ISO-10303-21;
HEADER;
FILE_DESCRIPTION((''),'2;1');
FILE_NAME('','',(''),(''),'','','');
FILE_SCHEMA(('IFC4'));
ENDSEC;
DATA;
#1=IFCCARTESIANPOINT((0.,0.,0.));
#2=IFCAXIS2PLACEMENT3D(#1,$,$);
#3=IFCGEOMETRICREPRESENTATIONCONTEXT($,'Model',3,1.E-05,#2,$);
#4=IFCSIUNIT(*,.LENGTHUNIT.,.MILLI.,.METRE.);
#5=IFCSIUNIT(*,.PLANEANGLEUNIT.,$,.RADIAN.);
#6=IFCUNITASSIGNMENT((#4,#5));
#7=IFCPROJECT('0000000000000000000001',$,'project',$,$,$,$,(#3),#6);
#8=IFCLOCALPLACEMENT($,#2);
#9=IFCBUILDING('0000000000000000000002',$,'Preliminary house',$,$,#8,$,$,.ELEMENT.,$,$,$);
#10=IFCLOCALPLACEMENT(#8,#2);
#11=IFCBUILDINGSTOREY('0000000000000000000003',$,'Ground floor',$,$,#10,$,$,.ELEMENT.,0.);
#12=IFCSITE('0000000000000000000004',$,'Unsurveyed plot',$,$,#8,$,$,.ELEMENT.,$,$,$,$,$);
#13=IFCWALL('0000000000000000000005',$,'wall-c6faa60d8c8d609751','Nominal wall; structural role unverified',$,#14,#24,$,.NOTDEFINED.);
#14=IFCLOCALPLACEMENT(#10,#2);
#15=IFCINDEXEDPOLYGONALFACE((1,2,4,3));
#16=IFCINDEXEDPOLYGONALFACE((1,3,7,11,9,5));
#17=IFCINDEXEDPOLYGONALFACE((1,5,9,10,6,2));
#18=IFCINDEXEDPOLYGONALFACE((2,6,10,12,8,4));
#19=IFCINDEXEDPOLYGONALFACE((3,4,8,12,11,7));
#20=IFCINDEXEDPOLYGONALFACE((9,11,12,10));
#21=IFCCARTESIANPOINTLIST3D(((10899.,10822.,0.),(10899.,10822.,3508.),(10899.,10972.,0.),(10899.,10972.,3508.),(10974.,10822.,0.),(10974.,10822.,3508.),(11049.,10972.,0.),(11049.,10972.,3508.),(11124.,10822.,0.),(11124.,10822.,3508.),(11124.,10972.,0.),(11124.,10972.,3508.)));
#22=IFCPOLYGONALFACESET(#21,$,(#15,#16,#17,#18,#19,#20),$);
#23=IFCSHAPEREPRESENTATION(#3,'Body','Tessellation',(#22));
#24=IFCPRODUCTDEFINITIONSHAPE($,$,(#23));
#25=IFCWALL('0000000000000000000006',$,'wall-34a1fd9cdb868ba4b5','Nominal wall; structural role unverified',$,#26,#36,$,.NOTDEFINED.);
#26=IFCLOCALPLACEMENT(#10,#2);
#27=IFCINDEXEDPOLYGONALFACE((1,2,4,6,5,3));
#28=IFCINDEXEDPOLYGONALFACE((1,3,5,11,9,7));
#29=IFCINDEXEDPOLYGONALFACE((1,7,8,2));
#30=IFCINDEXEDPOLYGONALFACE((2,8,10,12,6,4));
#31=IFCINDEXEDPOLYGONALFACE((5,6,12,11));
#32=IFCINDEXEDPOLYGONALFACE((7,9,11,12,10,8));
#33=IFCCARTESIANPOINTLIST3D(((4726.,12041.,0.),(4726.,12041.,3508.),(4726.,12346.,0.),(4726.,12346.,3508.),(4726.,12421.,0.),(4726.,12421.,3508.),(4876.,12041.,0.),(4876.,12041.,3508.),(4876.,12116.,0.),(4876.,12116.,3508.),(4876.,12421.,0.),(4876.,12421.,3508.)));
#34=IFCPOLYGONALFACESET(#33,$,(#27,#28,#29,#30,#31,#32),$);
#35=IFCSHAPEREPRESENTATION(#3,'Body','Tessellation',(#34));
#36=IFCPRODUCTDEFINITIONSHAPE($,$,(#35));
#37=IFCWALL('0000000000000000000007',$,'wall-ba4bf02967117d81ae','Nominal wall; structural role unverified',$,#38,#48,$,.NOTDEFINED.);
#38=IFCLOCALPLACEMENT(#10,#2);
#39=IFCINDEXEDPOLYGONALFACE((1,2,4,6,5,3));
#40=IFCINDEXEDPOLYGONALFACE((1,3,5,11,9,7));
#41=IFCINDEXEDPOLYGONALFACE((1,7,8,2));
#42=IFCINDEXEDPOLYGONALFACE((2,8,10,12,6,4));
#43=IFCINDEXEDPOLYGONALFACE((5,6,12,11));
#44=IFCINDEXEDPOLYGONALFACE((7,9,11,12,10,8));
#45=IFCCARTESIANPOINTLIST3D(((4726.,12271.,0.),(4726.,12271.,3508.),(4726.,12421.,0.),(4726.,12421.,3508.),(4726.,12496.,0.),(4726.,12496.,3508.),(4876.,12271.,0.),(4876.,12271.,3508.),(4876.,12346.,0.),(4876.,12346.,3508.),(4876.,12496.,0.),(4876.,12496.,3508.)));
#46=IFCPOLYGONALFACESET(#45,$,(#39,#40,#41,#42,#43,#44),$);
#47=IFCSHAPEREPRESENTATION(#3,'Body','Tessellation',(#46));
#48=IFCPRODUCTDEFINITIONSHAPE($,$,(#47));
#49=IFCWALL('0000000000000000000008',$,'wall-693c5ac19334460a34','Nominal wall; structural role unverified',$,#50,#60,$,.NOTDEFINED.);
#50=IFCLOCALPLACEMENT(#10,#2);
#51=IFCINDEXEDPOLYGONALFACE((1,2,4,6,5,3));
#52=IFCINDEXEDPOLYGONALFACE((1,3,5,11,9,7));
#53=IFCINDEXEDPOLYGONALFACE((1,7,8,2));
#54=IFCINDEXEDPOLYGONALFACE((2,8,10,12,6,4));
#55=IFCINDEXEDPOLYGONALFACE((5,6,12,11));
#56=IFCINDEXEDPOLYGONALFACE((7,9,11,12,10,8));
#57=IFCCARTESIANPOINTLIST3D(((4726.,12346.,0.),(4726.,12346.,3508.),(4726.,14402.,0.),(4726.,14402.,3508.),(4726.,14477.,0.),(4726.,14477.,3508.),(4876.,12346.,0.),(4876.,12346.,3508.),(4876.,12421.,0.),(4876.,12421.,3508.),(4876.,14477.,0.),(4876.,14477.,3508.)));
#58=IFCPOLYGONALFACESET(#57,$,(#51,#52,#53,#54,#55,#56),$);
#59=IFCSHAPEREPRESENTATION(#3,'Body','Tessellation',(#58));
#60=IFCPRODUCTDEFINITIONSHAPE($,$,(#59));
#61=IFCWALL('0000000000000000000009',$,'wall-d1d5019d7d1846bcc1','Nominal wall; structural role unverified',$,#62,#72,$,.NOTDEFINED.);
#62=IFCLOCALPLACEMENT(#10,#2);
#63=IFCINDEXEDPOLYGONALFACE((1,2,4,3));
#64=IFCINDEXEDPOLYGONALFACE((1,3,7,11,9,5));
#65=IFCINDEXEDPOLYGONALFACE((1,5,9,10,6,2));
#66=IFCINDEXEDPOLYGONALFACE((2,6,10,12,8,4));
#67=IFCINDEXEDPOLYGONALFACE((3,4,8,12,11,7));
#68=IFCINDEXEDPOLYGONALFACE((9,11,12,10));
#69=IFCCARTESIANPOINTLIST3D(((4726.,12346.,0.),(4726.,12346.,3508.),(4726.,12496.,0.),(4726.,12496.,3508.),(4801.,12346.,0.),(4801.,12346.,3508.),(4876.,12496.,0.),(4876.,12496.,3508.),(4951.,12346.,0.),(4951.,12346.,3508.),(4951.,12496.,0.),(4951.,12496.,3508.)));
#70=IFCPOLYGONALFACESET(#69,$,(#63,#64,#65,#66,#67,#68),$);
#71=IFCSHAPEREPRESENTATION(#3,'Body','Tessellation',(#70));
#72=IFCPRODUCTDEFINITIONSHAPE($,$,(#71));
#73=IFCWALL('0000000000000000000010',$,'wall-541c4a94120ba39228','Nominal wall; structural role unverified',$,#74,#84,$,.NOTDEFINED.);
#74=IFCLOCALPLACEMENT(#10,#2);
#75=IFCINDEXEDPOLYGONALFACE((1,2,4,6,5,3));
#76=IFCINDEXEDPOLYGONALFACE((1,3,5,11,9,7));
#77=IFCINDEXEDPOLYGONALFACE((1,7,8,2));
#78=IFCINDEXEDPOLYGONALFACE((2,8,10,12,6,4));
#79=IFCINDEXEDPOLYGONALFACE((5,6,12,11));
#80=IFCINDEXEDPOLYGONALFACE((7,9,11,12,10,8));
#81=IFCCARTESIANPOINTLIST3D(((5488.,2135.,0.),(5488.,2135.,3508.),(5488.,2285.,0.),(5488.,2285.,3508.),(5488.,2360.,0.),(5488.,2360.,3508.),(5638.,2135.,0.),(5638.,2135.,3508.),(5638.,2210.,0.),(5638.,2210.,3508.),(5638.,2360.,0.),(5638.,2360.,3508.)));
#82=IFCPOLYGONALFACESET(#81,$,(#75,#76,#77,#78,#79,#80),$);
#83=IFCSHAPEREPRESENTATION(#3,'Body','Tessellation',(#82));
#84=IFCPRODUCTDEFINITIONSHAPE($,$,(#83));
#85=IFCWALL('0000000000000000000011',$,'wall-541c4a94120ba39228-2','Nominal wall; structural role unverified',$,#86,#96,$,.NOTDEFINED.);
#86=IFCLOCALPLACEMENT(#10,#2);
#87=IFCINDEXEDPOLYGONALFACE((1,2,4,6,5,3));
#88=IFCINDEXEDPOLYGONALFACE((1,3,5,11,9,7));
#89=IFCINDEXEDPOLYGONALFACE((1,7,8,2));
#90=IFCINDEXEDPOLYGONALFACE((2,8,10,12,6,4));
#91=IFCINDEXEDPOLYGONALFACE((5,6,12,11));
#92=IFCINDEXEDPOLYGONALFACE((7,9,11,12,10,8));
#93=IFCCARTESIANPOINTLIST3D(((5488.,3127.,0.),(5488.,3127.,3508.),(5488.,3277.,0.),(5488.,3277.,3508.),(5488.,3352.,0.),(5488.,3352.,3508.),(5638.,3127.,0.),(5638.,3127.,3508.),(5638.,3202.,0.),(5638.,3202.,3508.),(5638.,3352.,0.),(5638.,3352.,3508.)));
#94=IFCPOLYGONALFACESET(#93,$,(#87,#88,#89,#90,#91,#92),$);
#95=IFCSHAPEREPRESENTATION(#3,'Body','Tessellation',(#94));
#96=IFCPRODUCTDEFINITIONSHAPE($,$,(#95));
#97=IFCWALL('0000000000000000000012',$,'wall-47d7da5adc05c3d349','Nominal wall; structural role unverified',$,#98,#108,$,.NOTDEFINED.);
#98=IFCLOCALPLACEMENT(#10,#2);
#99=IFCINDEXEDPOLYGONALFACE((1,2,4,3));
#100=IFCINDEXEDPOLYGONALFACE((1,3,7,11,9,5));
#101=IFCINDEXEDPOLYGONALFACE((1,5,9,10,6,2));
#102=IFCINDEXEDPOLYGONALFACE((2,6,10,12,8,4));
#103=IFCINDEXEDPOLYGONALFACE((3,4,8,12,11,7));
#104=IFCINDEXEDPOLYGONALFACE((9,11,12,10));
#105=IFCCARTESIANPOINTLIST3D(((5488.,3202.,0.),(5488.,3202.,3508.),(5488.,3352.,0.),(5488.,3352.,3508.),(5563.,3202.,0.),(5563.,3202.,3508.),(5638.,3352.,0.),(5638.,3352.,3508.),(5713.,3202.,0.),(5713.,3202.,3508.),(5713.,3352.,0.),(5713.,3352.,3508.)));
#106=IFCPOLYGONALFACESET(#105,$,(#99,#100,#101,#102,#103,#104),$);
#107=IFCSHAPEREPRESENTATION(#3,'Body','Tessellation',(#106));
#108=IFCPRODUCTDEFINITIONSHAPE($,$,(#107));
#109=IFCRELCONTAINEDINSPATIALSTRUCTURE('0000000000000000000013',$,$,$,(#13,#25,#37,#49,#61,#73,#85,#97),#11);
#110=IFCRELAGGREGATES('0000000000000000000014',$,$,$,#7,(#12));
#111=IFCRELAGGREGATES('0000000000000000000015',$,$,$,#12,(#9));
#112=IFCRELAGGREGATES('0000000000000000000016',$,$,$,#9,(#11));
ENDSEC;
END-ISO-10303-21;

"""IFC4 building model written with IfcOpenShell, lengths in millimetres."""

from ifc_helpers import new_model, si_unit, origin, place, context, project, spatial, polyline, outline, extrude, element, save


model = new_model("IFC4")

# Units and contexts
model_context = context("Model", 3, precision=1e-05, world=origin())
ifc_project = project(units=[si_unit("LENGTHUNIT", "METRE", prefix="MILLI"), si_unit("PLANEANGLEUNIT", "RADIAN")], contexts=[model_context])

# Site, building, storey
placement_1 = place(None, origin())
site = spatial("IfcSite", under=ifc_project, at=placement_1, Name="Unsurveyed plot", CompositionType="ELEMENT")
building = spatial("IfcBuilding", under=site, at=placement_1, Name="Preliminary house", CompositionType="ELEMENT")
placement_2 = place(placement_1, origin())
storey = spatial("IfcBuildingStorey", under=building, at=placement_2, Name="Ground floor", CompositionType="ELEMENT", Elevation=0.0)

# Walls
element("IfcWall", 1, at=placement_2, inside=storey, Name="wall-c6faa60d8c8d609751", Description="Nominal wall; structural role unverified", PredefinedType="NOTDEFINED", context=model_context, shape_type="SweptSolid", body=[
    extrude(outline(polyline([(11049.0, 10972.0), (11124.0, 10972.0), (11124.0, 10822.0), (10974.0, 10822.0), (10899.0, 10822.0), (10899.0, 10972.0), (11049.0, 10972.0)])), origin(), (0.0, 0.0, 1.0), 3508.0),
])
element("IfcWall", 2, at=placement_2, inside=storey, Name="wall-34a1fd9cdb868ba4b5", Description="Nominal wall; structural role unverified", PredefinedType="NOTDEFINED", context=model_context, shape_type="SweptSolid", body=[
    extrude(outline(polyline([(4726.0, 12346.0), (4726.0, 12421.0), (4876.0, 12421.0), (4876.0, 12116.0), (4876.0, 12041.0), (4726.0, 12041.0), (4726.0, 12346.0)])), origin(), (0.0, 0.0, 1.0), 3508.0),
])
element("IfcWall", 3, at=placement_2, inside=storey, Name="wall-ba4bf02967117d81ae", Description="Nominal wall; structural role unverified", PredefinedType="NOTDEFINED", context=model_context, shape_type="SweptSolid", body=[
    extrude(outline(polyline([(4726.0, 12421.0), (4726.0, 12496.0), (4876.0, 12496.0), (4876.0, 12346.0), (4876.0, 12271.0), (4726.0, 12271.0), (4726.0, 12421.0)])), origin(), (0.0, 0.0, 1.0), 3508.0),
])
element("IfcWall", 4, at=placement_2, inside=storey, Name="wall-693c5ac19334460a34", Description="Nominal wall; structural role unverified", PredefinedType="NOTDEFINED", context=model_context, shape_type="SweptSolid", body=[
    extrude(outline(polyline([(4726.0, 14402.0), (4726.0, 14477.0), (4876.0, 14477.0), (4876.0, 12421.0), (4876.0, 12346.0), (4726.0, 12346.0), (4726.0, 14402.0)])), origin(), (0.0, 0.0, 1.0), 3508.0),
])
element("IfcWall", 5, at=placement_2, inside=storey, Name="wall-d1d5019d7d1846bcc1", Description="Nominal wall; structural role unverified", PredefinedType="NOTDEFINED", context=model_context, shape_type="SweptSolid", body=[
    extrude(outline(polyline([(4876.0, 12496.0), (4951.0, 12496.0), (4951.0, 12346.0), (4801.0, 12346.0), (4726.0, 12346.0), (4726.0, 12496.0), (4876.0, 12496.0)])), origin(), (0.0, 0.0, 1.0), 3508.0),
])

# Wall
element("IfcWall", 6, at=placement_2, inside=storey, Name="wall-541c4a94120ba39228", Description="Nominal wall; structural role unverified", PredefinedType="NOTDEFINED", context=model_context, shape_type="SweptSolid", body=[
    extrude(outline(polyline([(5488.0, 2285.0), (5488.0, 2360.0), (5638.0, 2360.0), (5638.0, 2210.0), (5638.0, 2135.0), (5488.0, 2135.0), (5488.0, 2285.0)])), origin(), (0.0, 0.0, 1.0), 3508.0),
])

# Wall
element("IfcWall", 7, at=placement_2, inside=storey, Name="wall-541c4a94120ba39228-2", Description="Nominal wall; structural role unverified", PredefinedType="NOTDEFINED", context=model_context, shape_type="SweptSolid", body=[
    extrude(outline(polyline([(5488.0, 3277.0), (5488.0, 3352.0), (5638.0, 3352.0), (5638.0, 3202.0), (5638.0, 3127.0), (5488.0, 3127.0), (5488.0, 3277.0)])), origin(), (0.0, 0.0, 1.0), 3508.0),
])

# Wall
element("IfcWall", 8, at=placement_2, inside=storey, Name="wall-47d7da5adc05c3d349", Description="Nominal wall; structural role unverified", PredefinedType="NOTDEFINED", context=model_context, shape_type="SweptSolid", body=[
    extrude(outline(polyline([(5638.0, 3352.0), (5713.0, 3352.0), (5713.0, 3202.0), (5563.0, 3202.0), (5488.0, 3202.0), (5488.0, 3352.0), (5638.0, 3352.0)])), origin(), (0.0, 0.0, 1.0), 3508.0),
])

save(model, "model.ifc")
